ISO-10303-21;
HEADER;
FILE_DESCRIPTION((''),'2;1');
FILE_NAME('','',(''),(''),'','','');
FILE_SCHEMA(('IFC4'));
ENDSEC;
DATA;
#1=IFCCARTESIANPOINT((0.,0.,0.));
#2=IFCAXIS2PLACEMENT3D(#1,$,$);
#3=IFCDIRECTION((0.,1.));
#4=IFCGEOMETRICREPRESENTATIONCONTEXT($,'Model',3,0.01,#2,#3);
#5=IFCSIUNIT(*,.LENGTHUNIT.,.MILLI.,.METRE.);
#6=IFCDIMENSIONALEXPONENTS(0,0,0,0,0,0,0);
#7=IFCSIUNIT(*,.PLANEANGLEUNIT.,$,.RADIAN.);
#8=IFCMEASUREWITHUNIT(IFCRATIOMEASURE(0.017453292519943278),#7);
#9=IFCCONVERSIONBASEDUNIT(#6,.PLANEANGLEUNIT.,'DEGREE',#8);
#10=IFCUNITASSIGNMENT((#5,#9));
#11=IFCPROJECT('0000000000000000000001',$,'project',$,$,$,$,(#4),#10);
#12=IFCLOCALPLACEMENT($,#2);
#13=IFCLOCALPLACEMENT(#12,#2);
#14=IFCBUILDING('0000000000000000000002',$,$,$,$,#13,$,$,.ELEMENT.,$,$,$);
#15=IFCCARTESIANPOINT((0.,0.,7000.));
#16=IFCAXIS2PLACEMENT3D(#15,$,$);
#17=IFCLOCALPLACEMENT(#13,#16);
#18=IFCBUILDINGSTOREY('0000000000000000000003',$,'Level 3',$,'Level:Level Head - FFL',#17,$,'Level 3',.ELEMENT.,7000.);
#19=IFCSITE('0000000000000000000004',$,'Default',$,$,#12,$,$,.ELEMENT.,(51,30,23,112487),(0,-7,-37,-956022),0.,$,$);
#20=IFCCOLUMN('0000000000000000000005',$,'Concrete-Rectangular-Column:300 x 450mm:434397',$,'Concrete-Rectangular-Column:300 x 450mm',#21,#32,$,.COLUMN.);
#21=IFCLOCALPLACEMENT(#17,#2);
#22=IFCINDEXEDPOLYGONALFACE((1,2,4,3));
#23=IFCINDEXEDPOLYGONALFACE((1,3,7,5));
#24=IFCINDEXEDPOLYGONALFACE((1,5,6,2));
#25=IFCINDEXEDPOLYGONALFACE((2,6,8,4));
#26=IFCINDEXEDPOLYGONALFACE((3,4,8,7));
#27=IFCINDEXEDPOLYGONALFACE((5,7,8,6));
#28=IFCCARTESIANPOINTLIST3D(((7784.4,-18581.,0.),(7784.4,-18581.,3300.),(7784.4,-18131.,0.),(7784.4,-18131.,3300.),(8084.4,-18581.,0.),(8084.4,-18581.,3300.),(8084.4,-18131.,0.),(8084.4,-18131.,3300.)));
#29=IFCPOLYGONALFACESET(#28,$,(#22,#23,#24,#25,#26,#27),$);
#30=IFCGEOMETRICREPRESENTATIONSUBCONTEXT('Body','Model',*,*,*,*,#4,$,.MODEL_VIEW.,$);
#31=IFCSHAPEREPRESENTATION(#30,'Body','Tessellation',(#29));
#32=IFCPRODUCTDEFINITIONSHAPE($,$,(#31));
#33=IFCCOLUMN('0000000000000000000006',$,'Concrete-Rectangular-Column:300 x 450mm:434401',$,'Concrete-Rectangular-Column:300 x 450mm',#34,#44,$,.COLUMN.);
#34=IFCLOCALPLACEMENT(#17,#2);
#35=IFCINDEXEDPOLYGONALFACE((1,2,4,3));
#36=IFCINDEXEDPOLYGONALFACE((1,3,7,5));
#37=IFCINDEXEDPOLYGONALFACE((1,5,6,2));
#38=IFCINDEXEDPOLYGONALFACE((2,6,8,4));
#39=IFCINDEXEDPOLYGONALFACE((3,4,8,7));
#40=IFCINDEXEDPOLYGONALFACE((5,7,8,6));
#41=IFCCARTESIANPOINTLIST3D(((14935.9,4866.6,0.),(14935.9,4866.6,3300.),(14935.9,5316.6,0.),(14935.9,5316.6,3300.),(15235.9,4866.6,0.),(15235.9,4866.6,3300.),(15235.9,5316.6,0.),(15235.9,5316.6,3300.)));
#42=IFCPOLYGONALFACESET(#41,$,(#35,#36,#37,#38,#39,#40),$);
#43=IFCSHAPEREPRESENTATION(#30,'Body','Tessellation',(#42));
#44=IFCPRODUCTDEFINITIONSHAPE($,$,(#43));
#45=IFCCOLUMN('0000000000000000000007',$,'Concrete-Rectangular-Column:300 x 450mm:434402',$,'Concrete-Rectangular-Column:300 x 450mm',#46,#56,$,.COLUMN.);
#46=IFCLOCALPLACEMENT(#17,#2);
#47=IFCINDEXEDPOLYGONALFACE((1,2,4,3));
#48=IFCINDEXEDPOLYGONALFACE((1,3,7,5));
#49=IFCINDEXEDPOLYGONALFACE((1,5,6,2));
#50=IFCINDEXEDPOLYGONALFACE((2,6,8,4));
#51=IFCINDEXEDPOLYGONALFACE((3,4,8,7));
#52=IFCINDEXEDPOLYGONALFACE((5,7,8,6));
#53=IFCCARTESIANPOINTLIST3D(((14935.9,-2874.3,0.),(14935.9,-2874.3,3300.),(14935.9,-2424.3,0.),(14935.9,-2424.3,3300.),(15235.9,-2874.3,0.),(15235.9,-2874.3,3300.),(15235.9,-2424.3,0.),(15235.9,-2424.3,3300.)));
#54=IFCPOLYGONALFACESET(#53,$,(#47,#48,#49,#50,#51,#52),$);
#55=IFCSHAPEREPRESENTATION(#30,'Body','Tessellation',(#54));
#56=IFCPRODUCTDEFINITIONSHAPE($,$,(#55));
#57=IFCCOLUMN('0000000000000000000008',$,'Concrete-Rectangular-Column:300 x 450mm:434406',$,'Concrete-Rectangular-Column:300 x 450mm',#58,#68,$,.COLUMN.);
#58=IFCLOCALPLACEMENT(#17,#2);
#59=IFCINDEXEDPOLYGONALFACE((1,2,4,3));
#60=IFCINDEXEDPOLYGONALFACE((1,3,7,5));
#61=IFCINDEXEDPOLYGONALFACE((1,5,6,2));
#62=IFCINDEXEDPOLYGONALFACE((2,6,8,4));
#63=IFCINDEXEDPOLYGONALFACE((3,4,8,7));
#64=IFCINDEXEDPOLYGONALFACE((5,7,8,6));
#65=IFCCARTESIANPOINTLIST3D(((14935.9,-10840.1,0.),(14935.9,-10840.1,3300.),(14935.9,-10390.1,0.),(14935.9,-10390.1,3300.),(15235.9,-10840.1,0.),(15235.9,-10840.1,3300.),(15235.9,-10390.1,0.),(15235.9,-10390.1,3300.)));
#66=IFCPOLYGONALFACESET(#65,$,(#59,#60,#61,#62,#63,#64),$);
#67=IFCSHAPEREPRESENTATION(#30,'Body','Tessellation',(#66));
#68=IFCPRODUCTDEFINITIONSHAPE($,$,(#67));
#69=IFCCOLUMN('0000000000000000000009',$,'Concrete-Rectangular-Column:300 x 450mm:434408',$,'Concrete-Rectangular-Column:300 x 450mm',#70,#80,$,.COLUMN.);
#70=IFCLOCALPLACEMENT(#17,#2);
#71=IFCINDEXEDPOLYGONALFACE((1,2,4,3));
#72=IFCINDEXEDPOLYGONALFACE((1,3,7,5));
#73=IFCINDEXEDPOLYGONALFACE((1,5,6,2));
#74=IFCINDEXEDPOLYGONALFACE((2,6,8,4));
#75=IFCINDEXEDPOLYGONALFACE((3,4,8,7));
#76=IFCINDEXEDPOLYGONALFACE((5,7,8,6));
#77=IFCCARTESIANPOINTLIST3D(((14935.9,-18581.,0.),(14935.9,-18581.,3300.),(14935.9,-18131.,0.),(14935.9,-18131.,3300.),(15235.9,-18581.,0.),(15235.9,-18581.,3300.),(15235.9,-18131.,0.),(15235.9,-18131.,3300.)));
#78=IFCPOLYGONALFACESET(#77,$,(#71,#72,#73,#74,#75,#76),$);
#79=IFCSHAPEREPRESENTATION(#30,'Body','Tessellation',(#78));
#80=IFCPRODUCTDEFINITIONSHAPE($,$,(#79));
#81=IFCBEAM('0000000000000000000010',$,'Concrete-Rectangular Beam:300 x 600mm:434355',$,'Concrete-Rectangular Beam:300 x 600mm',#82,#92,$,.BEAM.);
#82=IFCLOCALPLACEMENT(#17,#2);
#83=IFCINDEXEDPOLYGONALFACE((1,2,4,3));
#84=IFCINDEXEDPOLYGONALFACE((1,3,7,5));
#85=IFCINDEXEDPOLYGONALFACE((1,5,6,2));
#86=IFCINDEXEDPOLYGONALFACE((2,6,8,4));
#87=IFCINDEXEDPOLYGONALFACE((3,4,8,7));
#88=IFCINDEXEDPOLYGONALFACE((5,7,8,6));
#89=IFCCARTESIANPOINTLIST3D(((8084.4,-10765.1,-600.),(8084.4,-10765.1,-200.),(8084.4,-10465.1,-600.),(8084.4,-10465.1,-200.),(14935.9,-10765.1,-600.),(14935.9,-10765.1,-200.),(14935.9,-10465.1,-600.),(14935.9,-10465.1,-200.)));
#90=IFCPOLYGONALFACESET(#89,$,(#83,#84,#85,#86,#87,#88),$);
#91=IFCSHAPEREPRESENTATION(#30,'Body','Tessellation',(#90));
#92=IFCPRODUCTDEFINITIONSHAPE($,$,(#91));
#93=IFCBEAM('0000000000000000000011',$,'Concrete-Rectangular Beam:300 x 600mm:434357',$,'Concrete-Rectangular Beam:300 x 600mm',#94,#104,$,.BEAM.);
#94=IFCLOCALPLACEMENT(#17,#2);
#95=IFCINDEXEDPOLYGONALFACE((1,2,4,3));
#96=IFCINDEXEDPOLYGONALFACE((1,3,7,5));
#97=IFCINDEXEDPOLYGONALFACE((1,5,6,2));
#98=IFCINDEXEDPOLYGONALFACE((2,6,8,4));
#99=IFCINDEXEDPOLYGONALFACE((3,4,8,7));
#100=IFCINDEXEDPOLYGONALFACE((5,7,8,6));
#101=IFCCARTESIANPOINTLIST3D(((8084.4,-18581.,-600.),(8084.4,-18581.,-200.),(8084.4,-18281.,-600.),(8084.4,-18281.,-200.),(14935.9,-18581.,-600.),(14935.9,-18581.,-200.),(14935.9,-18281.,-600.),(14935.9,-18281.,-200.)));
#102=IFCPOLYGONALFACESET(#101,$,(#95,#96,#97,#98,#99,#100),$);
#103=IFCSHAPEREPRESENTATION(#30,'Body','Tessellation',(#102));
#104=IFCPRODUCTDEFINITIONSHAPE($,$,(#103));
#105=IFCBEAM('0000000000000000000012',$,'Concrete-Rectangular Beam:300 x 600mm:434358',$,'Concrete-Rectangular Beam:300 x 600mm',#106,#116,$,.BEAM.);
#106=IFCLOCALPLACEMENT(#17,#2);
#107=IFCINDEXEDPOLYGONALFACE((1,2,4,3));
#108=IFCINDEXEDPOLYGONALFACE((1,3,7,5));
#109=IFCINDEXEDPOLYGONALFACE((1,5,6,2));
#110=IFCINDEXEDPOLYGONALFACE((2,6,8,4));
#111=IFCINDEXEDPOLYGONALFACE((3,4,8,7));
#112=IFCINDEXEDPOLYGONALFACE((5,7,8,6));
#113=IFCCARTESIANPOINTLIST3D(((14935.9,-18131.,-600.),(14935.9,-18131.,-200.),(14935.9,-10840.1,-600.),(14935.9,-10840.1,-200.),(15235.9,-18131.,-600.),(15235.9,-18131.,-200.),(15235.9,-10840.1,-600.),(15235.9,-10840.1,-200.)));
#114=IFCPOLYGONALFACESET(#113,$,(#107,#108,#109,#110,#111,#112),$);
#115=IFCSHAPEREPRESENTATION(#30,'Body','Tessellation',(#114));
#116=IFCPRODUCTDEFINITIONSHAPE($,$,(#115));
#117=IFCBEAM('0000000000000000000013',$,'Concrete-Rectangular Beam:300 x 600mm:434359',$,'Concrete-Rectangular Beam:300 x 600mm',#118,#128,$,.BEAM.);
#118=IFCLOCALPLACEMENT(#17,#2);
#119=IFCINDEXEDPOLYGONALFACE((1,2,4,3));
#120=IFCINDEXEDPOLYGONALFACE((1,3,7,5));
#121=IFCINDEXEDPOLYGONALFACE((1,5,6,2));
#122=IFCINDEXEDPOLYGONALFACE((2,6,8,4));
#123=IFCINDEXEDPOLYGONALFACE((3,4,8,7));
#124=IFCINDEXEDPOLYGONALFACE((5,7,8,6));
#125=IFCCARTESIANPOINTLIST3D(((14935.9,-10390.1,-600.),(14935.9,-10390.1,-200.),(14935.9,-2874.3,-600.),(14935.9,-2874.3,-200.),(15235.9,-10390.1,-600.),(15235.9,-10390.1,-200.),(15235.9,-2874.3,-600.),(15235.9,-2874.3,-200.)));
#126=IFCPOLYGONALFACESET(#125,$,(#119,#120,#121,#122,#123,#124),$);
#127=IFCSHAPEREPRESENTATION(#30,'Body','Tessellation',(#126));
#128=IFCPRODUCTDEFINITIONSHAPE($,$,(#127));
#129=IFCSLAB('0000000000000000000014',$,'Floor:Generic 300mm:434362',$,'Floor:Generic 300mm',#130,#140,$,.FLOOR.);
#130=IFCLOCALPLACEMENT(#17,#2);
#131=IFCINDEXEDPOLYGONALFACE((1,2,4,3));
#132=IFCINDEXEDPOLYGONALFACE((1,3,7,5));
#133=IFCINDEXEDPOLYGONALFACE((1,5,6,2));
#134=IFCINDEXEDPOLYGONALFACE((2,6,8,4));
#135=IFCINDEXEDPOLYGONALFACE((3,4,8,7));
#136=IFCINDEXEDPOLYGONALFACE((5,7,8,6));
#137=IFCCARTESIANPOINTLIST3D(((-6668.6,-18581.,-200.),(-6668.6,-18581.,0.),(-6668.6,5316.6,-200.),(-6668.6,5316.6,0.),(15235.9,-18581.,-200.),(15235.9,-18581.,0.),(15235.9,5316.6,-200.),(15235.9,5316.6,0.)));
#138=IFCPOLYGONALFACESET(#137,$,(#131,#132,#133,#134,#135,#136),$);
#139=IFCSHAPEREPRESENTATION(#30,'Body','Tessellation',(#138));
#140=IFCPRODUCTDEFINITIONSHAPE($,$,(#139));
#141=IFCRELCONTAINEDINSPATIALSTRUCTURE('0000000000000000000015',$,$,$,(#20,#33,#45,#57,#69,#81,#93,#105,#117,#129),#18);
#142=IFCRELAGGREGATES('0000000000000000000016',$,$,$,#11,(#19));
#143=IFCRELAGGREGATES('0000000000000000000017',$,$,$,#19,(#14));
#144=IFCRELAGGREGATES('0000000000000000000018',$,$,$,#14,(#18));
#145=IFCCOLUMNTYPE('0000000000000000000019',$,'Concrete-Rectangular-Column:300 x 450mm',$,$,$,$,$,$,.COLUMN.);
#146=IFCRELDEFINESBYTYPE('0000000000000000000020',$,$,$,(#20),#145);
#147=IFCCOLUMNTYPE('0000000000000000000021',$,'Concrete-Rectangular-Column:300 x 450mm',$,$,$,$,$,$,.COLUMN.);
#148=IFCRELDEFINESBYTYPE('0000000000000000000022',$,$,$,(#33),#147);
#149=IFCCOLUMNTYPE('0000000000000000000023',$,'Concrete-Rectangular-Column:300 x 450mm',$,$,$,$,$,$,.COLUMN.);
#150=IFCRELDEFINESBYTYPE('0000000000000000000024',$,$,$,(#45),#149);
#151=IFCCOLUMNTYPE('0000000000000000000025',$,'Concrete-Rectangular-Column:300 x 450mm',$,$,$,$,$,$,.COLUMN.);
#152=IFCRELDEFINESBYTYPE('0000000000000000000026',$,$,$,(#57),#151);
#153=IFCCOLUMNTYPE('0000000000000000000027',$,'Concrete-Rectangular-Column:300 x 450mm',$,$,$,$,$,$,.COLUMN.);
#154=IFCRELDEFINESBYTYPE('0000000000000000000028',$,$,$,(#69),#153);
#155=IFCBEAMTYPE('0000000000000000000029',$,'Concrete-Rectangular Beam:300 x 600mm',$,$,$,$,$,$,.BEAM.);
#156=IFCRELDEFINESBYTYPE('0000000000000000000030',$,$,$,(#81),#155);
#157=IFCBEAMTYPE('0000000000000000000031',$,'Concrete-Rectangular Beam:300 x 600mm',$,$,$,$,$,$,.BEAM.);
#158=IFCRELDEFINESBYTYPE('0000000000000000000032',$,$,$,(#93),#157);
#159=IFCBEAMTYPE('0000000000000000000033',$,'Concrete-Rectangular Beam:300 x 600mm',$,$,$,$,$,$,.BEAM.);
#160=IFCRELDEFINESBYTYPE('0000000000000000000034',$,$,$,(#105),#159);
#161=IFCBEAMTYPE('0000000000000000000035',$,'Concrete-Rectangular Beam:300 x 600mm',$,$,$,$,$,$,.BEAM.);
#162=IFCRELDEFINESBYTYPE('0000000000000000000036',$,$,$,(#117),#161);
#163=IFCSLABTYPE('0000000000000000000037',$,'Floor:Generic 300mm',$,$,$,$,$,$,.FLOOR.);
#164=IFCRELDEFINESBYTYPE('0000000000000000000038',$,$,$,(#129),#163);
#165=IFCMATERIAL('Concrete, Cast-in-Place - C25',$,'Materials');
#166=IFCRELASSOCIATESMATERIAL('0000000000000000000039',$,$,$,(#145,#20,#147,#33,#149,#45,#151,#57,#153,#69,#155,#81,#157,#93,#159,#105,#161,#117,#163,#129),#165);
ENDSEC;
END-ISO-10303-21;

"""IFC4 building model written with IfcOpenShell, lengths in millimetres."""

from ifc_helpers import new_model, entity, si_unit, converted_unit, direction, frame, origin, place, context, subcontext, project, spatial, indexed_curve, outline, extrude, source, transform, mapped, material, type_object, type_shapes, element, save


model = new_model("IFC4")

# Units and contexts
model_context = context("Model", 3, precision=0.01, world=origin(), true_north=direction((0.0, 1.0)))
body_context = subcontext(model_context, "Body", "Model", "MODEL_VIEW")
ifc_project = project(units=[si_unit("LENGTHUNIT", "METRE", prefix="MILLI"), converted_unit("PLANEANGLEUNIT", "DEGREE", entity("IfcRatioMeasure", 0.017453292519943278), si_unit("PLANEANGLEUNIT", "RADIAN"), dimensions=[0, 0, 0, 0, 0, 0, 0])], contexts=[model_context])

# Site, building, storey
site_placement = place(None, origin())
site = spatial("IfcSite", under=ifc_project, at=site_placement, Name="Default", CompositionType="ELEMENT", RefLatitude=(51, 30, 23, 112487), RefLongitude=(0, -7, -37, -956022), RefElevation=0.0)
building_placement = place(site_placement, origin())
building = spatial("IfcBuilding", under=site, at=building_placement, CompositionType="ELEMENT")
storey_placement = place(building_placement, frame((0.0, 0.0, 7000.0)))
storey = spatial("IfcBuildingStorey", under=building, at=storey_placement, Name="Level 3", ObjectType="Level:Level Head - FFL", LongName="Level 3", CompositionType="ELEMENT", Elevation=7000.0)

# Columns
ifc_material = material(Name="Concrete, Cast-in-Place - C25", Category="Materials")
column_type_1 = type_object("IfcColumnType", Name="Concrete-Rectangular-Column:300 x 450mm", PredefinedType="COLUMN", material=ifc_material)
shared_shape_1 = source(origin(), body_context, "Body", "SweptSolid", [
    extrude(outline(indexed_curve([(-225.0, -150.0), (225.0, -150.0), (225.0, 150.0), (-225.0, 150.0), (-225.0, -150.0)], self_intersect=False)), frame((7934.4, -18356.0, 7000.0), z_axis=(0.0, 0.0, 1.0), x_axis=(0.0, -1.0, 0.0)), (0.0, 0.0, 1.0), 3300.0),
])
type_shapes(column_type_1, [shared_shape_1])
column_1_placement = place(storey_placement, frame((0.0, 0.0, -7000.0)))
element("IfcColumn", 1, at=column_1_placement, inside=storey, type_object=column_type_1, material=ifc_material, Name="Concrete-Rectangular-Column:300 x 450mm:434397", ObjectType="Concrete-Rectangular-Column:300 x 450mm", PredefinedType="COLUMN", context=body_context, shape_type="MappedRepresentation", body=[
    mapped(shared_shape_1, transform((0.0, 0.0, 0.0), scale=1.0)),
])
column_type_2 = type_object("IfcColumnType", Name="Concrete-Rectangular-Column:300 x 450mm", PredefinedType="COLUMN", material=ifc_material)
shared_shape_2 = source(origin(), body_context, "Body", "SweptSolid", [
    extrude(outline(indexed_curve([(-225.0, -150.0), (225.0, -150.0), (225.0, 150.0), (-225.0, 150.0), (-225.0, -150.0)], self_intersect=False)), frame((15085.9, 5091.6, 7000.0), z_axis=(0.0, 0.0, 1.0), x_axis=(0.0, -1.0, 0.0)), (0.0, 0.0, 1.0), 3300.0),
])
type_shapes(column_type_2, [shared_shape_2])
column_2_placement = place(storey_placement, frame((0.0, 0.0, -7000.0)))
element("IfcColumn", 2, at=column_2_placement, inside=storey, type_object=column_type_2, material=ifc_material, Name="Concrete-Rectangular-Column:300 x 450mm:434401", ObjectType="Concrete-Rectangular-Column:300 x 450mm", PredefinedType="COLUMN", context=body_context, shape_type="MappedRepresentation", body=[
    mapped(shared_shape_2, transform((0.0, 0.0, 0.0), scale=1.0)),
])
column_type_3 = type_object("IfcColumnType", Name="Concrete-Rectangular-Column:300 x 450mm", PredefinedType="COLUMN", material=ifc_material)
shared_shape_3 = source(origin(), body_context, "Body", "SweptSolid", [
    extrude(outline(indexed_curve([(-225.0, -150.0), (225.0, -150.0), (225.0, 150.0), (-225.0, 150.0), (-225.0, -150.0)], self_intersect=False)), frame((15085.9, -2649.3, 7000.0), z_axis=(0.0, 0.0, 1.0), x_axis=(0.0, -1.0, 0.0)), (0.0, 0.0, 1.0), 3300.0),
])
type_shapes(column_type_3, [shared_shape_3])
column_3_placement = place(storey_placement, frame((0.0, 0.0, -7000.0)))
element("IfcColumn", 3, at=column_3_placement, inside=storey, type_object=column_type_3, material=ifc_material, Name="Concrete-Rectangular-Column:300 x 450mm:434402", ObjectType="Concrete-Rectangular-Column:300 x 450mm", PredefinedType="COLUMN", context=body_context, shape_type="MappedRepresentation", body=[
    mapped(shared_shape_3, transform((0.0, 0.0, 0.0), scale=1.0)),
])
column_type_4 = type_object("IfcColumnType", Name="Concrete-Rectangular-Column:300 x 450mm", PredefinedType="COLUMN", material=ifc_material)
shared_shape_4 = source(origin(), body_context, "Body", "SweptSolid", [
    extrude(outline(indexed_curve([(-225.0, -150.0), (225.0, -150.0), (225.0, 150.0), (-225.0, 150.0), (-225.0, -150.0)], self_intersect=False)), frame((15085.9, -10615.1, 7000.0), z_axis=(0.0, 0.0, 1.0), x_axis=(0.0, -1.0, 0.0)), (0.0, 0.0, 1.0), 3300.0),
])
type_shapes(column_type_4, [shared_shape_4])
column_4_placement = place(storey_placement, frame((0.0, 0.0, -7000.0)))
element("IfcColumn", 4, at=column_4_placement, inside=storey, type_object=column_type_4, material=ifc_material, Name="Concrete-Rectangular-Column:300 x 450mm:434406", ObjectType="Concrete-Rectangular-Column:300 x 450mm", PredefinedType="COLUMN", context=body_context, shape_type="MappedRepresentation", body=[
    mapped(shared_shape_4, transform((0.0, 0.0, 0.0), scale=1.0)),
])
column_type_5 = type_object("IfcColumnType", Name="Concrete-Rectangular-Column:300 x 450mm", PredefinedType="COLUMN", material=ifc_material)
shared_shape_5 = source(origin(), body_context, "Body", "SweptSolid", [
    extrude(outline(indexed_curve([(-225.0, -150.0), (225.0, -150.0), (225.0, 150.0), (-225.0, 150.0), (-225.0, -150.0)], self_intersect=False)), frame((15085.9, -18356.0, 7000.0), z_axis=(0.0, 0.0, 1.0), x_axis=(0.0, -1.0, 0.0)), (0.0, 0.0, 1.0), 3300.0),
])
type_shapes(column_type_5, [shared_shape_5])
column_5_placement = place(storey_placement, frame((0.0, 0.0, -7000.0)))
element("IfcColumn", 5, at=column_5_placement, inside=storey, type_object=column_type_5, material=ifc_material, Name="Concrete-Rectangular-Column:300 x 450mm:434408", ObjectType="Concrete-Rectangular-Column:300 x 450mm", PredefinedType="COLUMN", context=body_context, shape_type="MappedRepresentation", body=[
    mapped(shared_shape_5, transform((0.0, 0.0, 0.0), scale=1.0)),
])

# Beams
beam_type_1 = type_object("IfcBeamType", Name="Concrete-Rectangular Beam:300 x 600mm", PredefinedType="BEAM", material=ifc_material)
shared_shape_6 = source(origin(), body_context, "Body", "SweptSolid", [
    extrude(outline(indexed_curve([(-200.0, -150.0), (200.0, -150.0), (200.0, 150.0), (-200.0, 150.0), (-200.0, -150.0)], self_intersect=False)), frame((14935.9, -10615.1, 6600.0), z_axis=(-1.0, 0.0, 0.0), x_axis=(0.0, 0.0, -1.0)), (0.0, 0.0, 1.0), 6851.5),
])
type_shapes(beam_type_1, [shared_shape_6])
beam_1_placement = place(storey_placement, frame((0.0, 0.0, -7000.0)))
element("IfcBeam", 6, at=beam_1_placement, inside=storey, type_object=beam_type_1, material=ifc_material, Name="Concrete-Rectangular Beam:300 x 600mm:434355", ObjectType="Concrete-Rectangular Beam:300 x 600mm", PredefinedType="BEAM", context=body_context, shape_type="MappedRepresentation", body=[
    mapped(shared_shape_6, transform((0.0, 0.0, 0.0), scale=1.0)),
])
beam_type_2 = type_object("IfcBeamType", Name="Concrete-Rectangular Beam:300 x 600mm", PredefinedType="BEAM", material=ifc_material)
shared_shape_7 = source(origin(), body_context, "Body", "SweptSolid", [
    extrude(outline(indexed_curve([(-200.0, -150.0), (200.0, -150.0), (200.0, 150.0), (-200.0, 150.0), (-200.0, -150.0)], self_intersect=False)), frame((14935.9, -18431.0, 6600.0), z_axis=(-1.0, 0.0, 0.0), x_axis=(0.0, 0.0, -1.0)), (0.0, 0.0, 1.0), 6851.5),
])
type_shapes(beam_type_2, [shared_shape_7])
beam_2_placement = place(storey_placement, frame((0.0, 0.0, -7000.0)))
element("IfcBeam", 7, at=beam_2_placement, inside=storey, type_object=beam_type_2, material=ifc_material, Name="Concrete-Rectangular Beam:300 x 600mm:434357", ObjectType="Concrete-Rectangular Beam:300 x 600mm", PredefinedType="BEAM", context=body_context, shape_type="MappedRepresentation", body=[
    mapped(shared_shape_7, transform((0.0, 0.0, 0.0), scale=1.0)),
])
beam_type_3 = type_object("IfcBeamType", Name="Concrete-Rectangular Beam:300 x 600mm", PredefinedType="BEAM", material=ifc_material)
shared_shape_8 = source(origin(), body_context, "Body", "SweptSolid", [
    extrude(outline(indexed_curve([(-150.0, -200.0), (150.0, -200.0), (150.0, 200.0), (-150.0, 200.0), (-150.0, -200.0)], self_intersect=False)), frame((15085.9, -18131.0, 6600.0), z_axis=(0.0, 1.0, 0.0), x_axis=(-1.0, 0.0, 0.0)), (0.0, 0.0, 1.0), 7290.9),
])
type_shapes(beam_type_3, [shared_shape_8])
beam_3_placement = place(storey_placement, frame((0.0, 0.0, -7000.0)))
element("IfcBeam", 8, at=beam_3_placement, inside=storey, type_object=beam_type_3, material=ifc_material, Name="Concrete-Rectangular Beam:300 x 600mm:434358", ObjectType="Concrete-Rectangular Beam:300 x 600mm", PredefinedType="BEAM", context=body_context, shape_type="MappedRepresentation", body=[
    mapped(shared_shape_8, transform((0.0, 0.0, 0.0), scale=1.0)),
])
beam_type_4 = type_object("IfcBeamType", Name="Concrete-Rectangular Beam:300 x 600mm", PredefinedType="BEAM", material=ifc_material)
shared_shape_9 = source(origin(), body_context, "Body", "SweptSolid", [
    extrude(outline(indexed_curve([(-150.0, -200.0), (150.0, -200.0), (150.0, 200.0), (-150.0, 200.0), (-150.0, -200.0)], self_intersect=False)), frame((15085.9, -10390.1, 6600.0), z_axis=(0.0, 1.0, 0.0), x_axis=(-1.0, 0.0, 0.0)), (0.0, 0.0, 1.0), 7515.9),
])
type_shapes(beam_type_4, [shared_shape_9])
beam_4_placement = place(storey_placement, frame((0.0, 0.0, -7000.0)))
element("IfcBeam", 9, at=beam_4_placement, inside=storey, type_object=beam_type_4, material=ifc_material, Name="Concrete-Rectangular Beam:300 x 600mm:434359", ObjectType="Concrete-Rectangular Beam:300 x 600mm", PredefinedType="BEAM", context=body_context, shape_type="MappedRepresentation", body=[
    mapped(shared_shape_9, transform((0.0, 0.0, 0.0), scale=1.0)),
])

# Slab
slab_type = type_object("IfcSlabType", Name="Floor:Generic 300mm", PredefinedType="FLOOR", material=ifc_material)
slab_placement = place(storey_placement, origin())
element("IfcSlab", 10, at=slab_placement, inside=storey, type_object=slab_type, material=ifc_material, Name="Floor:Generic 300mm:434362", ObjectType="Floor:Generic 300mm", PredefinedType="FLOOR", context=body_context, shape_type="SweptSolid", body=[
    extrude(outline(indexed_curve([(-11948.8, -10952.2), (11948.8, -10952.2), (11948.8, 10952.2), (-11948.8, 10952.2), (-11948.8, -10952.2)], self_intersect=False)), frame((4283.6, -6632.2, 0.0), z_axis=(0.0, 0.0, -1.0), x_axis=(0.0, 1.0, 0.0)), (0.0, 0.0, 1.0), 200.0),
])

save(model, "model.ifc")
